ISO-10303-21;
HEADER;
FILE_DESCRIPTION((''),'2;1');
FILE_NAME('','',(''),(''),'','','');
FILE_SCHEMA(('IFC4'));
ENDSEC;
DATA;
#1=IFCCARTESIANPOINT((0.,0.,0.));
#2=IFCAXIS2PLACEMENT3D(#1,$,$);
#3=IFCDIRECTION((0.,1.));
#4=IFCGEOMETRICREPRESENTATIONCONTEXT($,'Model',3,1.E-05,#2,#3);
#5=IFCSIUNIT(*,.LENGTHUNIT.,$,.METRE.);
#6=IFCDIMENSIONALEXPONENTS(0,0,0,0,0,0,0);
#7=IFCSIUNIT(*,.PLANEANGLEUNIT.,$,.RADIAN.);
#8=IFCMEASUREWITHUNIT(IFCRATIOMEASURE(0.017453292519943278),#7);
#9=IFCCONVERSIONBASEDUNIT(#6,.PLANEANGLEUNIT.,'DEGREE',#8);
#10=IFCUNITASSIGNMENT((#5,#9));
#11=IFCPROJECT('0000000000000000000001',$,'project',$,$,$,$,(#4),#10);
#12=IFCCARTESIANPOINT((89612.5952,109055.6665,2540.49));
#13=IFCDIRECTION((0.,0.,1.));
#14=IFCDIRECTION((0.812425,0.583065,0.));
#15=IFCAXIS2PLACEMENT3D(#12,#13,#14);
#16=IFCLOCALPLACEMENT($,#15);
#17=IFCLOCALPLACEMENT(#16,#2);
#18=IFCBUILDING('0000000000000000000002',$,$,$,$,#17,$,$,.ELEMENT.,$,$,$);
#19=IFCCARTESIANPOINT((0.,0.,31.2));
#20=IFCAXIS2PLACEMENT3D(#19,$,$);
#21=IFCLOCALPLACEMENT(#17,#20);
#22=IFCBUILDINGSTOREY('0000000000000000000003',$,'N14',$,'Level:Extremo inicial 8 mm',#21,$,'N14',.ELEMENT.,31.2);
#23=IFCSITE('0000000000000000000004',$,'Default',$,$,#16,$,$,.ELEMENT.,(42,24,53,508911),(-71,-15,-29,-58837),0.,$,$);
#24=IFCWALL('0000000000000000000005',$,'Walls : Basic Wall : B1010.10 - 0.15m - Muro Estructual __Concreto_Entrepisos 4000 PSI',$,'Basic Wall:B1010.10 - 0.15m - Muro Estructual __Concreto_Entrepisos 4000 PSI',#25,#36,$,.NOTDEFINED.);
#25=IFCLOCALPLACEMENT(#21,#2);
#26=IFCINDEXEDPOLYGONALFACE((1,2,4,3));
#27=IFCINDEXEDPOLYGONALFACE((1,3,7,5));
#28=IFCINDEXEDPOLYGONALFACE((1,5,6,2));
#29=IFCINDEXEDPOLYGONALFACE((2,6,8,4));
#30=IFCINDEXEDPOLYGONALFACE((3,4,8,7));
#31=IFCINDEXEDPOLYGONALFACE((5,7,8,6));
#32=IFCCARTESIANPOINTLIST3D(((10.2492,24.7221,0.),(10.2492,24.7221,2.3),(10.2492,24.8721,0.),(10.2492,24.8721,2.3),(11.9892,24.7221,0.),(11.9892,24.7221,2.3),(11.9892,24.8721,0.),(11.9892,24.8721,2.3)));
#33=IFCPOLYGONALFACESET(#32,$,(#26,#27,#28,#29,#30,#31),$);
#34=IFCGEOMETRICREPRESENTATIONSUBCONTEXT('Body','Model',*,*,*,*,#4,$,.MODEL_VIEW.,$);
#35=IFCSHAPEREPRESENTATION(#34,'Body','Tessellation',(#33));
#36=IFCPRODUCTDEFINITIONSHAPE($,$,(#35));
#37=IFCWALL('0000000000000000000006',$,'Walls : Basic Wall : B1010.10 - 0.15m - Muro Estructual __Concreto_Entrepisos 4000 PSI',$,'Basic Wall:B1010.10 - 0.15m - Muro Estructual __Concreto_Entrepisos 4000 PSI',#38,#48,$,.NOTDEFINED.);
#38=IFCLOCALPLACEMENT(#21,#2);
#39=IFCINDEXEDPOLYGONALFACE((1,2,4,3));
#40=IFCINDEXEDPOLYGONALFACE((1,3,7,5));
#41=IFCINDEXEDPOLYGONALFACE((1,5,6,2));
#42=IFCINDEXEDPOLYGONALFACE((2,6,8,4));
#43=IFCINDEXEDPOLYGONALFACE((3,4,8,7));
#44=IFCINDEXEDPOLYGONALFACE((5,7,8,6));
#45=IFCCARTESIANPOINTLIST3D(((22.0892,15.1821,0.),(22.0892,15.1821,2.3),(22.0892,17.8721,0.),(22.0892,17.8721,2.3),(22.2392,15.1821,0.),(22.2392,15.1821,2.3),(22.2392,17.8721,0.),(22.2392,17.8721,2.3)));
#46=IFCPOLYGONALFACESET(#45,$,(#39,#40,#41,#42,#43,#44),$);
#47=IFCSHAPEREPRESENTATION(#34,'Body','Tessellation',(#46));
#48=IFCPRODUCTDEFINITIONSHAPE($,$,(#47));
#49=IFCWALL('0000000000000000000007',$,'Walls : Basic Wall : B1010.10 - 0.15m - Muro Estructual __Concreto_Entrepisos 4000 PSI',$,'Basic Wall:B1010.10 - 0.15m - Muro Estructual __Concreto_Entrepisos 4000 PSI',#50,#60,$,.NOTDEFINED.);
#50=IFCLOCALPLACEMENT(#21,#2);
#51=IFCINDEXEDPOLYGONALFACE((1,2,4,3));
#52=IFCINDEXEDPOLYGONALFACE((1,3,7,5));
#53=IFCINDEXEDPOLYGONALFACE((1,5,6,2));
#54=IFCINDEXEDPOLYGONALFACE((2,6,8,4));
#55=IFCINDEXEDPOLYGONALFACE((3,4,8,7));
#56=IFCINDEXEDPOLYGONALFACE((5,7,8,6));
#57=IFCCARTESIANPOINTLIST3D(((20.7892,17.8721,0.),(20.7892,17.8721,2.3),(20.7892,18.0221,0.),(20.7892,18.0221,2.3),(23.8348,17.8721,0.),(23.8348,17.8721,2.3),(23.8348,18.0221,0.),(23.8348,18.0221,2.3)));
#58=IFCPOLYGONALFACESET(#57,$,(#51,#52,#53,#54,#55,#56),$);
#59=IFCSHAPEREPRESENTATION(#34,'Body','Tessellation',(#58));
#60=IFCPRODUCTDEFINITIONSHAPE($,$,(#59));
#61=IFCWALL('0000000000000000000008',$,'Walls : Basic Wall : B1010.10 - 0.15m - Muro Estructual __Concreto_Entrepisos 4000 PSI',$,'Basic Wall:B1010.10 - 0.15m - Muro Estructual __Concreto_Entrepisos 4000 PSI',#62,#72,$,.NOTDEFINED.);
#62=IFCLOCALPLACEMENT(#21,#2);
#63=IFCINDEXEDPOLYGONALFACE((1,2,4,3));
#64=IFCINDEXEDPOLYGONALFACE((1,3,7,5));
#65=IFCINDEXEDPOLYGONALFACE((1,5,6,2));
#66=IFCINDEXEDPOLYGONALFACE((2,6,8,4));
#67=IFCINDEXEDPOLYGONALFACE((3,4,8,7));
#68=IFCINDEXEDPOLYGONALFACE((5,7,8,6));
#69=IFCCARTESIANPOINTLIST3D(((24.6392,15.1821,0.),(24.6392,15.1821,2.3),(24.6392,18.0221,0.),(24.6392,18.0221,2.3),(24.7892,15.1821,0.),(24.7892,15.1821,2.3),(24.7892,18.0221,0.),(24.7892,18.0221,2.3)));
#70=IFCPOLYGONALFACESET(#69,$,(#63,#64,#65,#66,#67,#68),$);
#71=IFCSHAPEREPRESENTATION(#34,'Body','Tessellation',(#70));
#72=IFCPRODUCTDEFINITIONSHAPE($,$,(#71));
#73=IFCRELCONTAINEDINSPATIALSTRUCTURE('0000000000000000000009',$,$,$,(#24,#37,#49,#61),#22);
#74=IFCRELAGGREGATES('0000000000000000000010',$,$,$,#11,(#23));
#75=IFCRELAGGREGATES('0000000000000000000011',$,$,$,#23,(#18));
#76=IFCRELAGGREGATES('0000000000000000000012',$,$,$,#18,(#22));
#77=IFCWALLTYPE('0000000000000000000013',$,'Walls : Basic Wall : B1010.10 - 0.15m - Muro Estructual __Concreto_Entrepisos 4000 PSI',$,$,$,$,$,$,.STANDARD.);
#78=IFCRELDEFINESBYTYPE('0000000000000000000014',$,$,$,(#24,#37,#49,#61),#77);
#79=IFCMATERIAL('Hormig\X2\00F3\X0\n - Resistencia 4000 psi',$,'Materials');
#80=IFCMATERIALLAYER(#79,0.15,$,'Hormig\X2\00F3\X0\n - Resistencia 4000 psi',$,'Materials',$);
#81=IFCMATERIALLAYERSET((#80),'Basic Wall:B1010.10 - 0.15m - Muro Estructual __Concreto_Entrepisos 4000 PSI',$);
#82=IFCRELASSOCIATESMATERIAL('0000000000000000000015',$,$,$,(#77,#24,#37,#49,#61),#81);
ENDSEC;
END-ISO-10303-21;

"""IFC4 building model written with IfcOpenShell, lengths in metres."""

from ifc_helpers import new_model, entity, si_unit, converted_unit, direction, frame, frame_2d, origin, place, context, subcontext, project, spatial, rectangle, extrude, material, layer, layer_set, layer_usage, type_object, element, save


model = new_model("IFC4")

# Units and contexts
model_context = context("Model", 3, precision=1e-05, world=origin(), true_north=direction((0.0, 1.0)))
body_context = subcontext(model_context, "Body", "Model", "MODEL_VIEW")
ifc_project = project(units=[si_unit("LENGTHUNIT", "METRE"), converted_unit("PLANEANGLEUNIT", "DEGREE", entity("IfcRatioMeasure", 0.017453292519943278), si_unit("PLANEANGLEUNIT", "RADIAN"), dimensions=[0, 0, 0, 0, 0, 0, 0])], contexts=[model_context])

# Site, building, storey
site_placement = place(None, frame((89612.5952, 109055.6665, 2540.49), z_axis=(0.0, 0.0, 1.0), x_axis=(0.812425, 0.583065, 0.0)))
site = spatial("IfcSite", under=ifc_project, at=site_placement, Name="Default", CompositionType="ELEMENT", RefLatitude=(42, 24, 53, 508911), RefLongitude=(-71, -15, -29, -58837), RefElevation=0.0)
building_placement = place(site_placement, origin())
building = spatial("IfcBuilding", under=site, at=building_placement, CompositionType="ELEMENT")
storey_placement = place(building_placement, frame((0.0, 0.0, 31.2)))
storey = spatial("IfcBuildingStorey", under=building, at=storey_placement, Name="N14", ObjectType="Level:Extremo inicial 8 mm", LongName="N14", CompositionType="ELEMENT", Elevation=31.2)

# Walls
ifc_material = material(Name="Hormigón - Resistencia 4000 psi", Category="Materials")
ifc_layer_1 = layer(ifc_material, 0.15, Name="Hormigón - Resistencia 4000 psi", Category="Materials")
ifc_layer_set_1 = layer_set([ifc_layer_1], Name="Basic Wall:B1010.10 - 0.15m - Muro Estructual __Concreto_Entrepisos 4000 PSI")
wall_type_1 = type_object("IfcWallType", Name="Walls : Basic Wall : B1010.10 - 0.15m - Muro Estructual __Concreto_Entrepisos 4000 PSI", PredefinedType="STANDARD", material=ifc_layer_set_1)
ifc_layer_usage_1 = layer_usage(ifc_layer_set_1, "AXIS2", "POSITIVE", -0.075)
wall_1_placement = place(storey_placement, frame((11.9892, 24.7971, 0.0), z_axis=(0.0, 0.0, 1.0), x_axis=(-1.0, 0.0, 0.0)))
element("IfcWall", 1, at=wall_1_placement, inside=storey, type_object=wall_type_1, material=ifc_layer_usage_1, Name="Walls : Basic Wall : B1010.10 - 0.15m - Muro Estructual __Concreto_Entrepisos 4000 PSI", ObjectType="Basic Wall:B1010.10 - 0.15m - Muro Estructual __Concreto_Entrepisos 4000 PSI", PredefinedType="NOTDEFINED", context=body_context, shape_type="SweptSolid", body=[
    extrude(rectangle(XDim=1.74, YDim=0.15, at=frame_2d((0.87, 0.0), x_axis=(-1.0, 0.0))), origin(), (0.0, 0.0, 1.0), 2.3),
])
ifc_layer_usage_2 = layer_usage(ifc_layer_set_1, "AXIS2", "POSITIVE", -0.075)
wall_2_placement = place(storey_placement, frame((22.1642, 15.1821, 0.0), z_axis=(0.0, 0.0, 1.0), x_axis=(0.0, 1.0, 0.0)))
element("IfcWall", 2, at=wall_2_placement, inside=storey, type_object=wall_type_1, material=ifc_layer_usage_2, Name="Walls : Basic Wall : B1010.10 - 0.15m - Muro Estructual __Concreto_Entrepisos 4000 PSI", ObjectType="Basic Wall:B1010.10 - 0.15m - Muro Estructual __Concreto_Entrepisos 4000 PSI", PredefinedType="NOTDEFINED", context=body_context, shape_type="SweptSolid", body=[
    extrude(rectangle(XDim=2.69, YDim=0.15, at=frame_2d((1.345, 0.0), x_axis=(-1.0, 0.0))), origin(), (0.0, 0.0, 1.0), 2.3),
])
ifc_layer_usage_3 = layer_usage(ifc_layer_set_1, "AXIS2", "POSITIVE", -0.075)
wall_3_placement = place(storey_placement, frame((20.7892, 17.9471, 0.0)))
element("IfcWall", 3, at=wall_3_placement, inside=storey, type_object=wall_type_1, material=ifc_layer_usage_3, Name="Walls : Basic Wall : B1010.10 - 0.15m - Muro Estructual __Concreto_Entrepisos 4000 PSI", ObjectType="Basic Wall:B1010.10 - 0.15m - Muro Estructual __Concreto_Entrepisos 4000 PSI", PredefinedType="NOTDEFINED", context=body_context, shape_type="SweptSolid", body=[
    extrude(rectangle(XDim=3.0455, YDim=0.15, at=frame_2d((1.5228, 0.0), x_axis=(-1.0, 0.0))), origin(), (0.0, 0.0, 1.0), 2.3),
])
ifc_layer_usage_4 = layer_usage(ifc_layer_set_1, "AXIS2", "POSITIVE", -0.075)
wall_4_placement = place(storey_placement, frame((24.7142, 15.1821, 0.0), z_axis=(0.0, 0.0, 1.0), x_axis=(0.0, 1.0, 0.0)))
element("IfcWall", 4, at=wall_4_placement, inside=storey, type_object=wall_type_1, material=ifc_layer_usage_4, Name="Walls : Basic Wall : B1010.10 - 0.15m - Muro Estructual __Concreto_Entrepisos 4000 PSI", ObjectType="Basic Wall:B1010.10 - 0.15m - Muro Estructual __Concreto_Entrepisos 4000 PSI", PredefinedType="NOTDEFINED", context=body_context, shape_type="SweptSolid", body=[
    extrude(rectangle(XDim=2.84, YDim=0.15, at=frame_2d((1.42, 0.0), x_axis=(-1.0, 0.0))), origin(), (0.0, 0.0, 1.0), 2.3),
])

save(model, "model.ifc")
